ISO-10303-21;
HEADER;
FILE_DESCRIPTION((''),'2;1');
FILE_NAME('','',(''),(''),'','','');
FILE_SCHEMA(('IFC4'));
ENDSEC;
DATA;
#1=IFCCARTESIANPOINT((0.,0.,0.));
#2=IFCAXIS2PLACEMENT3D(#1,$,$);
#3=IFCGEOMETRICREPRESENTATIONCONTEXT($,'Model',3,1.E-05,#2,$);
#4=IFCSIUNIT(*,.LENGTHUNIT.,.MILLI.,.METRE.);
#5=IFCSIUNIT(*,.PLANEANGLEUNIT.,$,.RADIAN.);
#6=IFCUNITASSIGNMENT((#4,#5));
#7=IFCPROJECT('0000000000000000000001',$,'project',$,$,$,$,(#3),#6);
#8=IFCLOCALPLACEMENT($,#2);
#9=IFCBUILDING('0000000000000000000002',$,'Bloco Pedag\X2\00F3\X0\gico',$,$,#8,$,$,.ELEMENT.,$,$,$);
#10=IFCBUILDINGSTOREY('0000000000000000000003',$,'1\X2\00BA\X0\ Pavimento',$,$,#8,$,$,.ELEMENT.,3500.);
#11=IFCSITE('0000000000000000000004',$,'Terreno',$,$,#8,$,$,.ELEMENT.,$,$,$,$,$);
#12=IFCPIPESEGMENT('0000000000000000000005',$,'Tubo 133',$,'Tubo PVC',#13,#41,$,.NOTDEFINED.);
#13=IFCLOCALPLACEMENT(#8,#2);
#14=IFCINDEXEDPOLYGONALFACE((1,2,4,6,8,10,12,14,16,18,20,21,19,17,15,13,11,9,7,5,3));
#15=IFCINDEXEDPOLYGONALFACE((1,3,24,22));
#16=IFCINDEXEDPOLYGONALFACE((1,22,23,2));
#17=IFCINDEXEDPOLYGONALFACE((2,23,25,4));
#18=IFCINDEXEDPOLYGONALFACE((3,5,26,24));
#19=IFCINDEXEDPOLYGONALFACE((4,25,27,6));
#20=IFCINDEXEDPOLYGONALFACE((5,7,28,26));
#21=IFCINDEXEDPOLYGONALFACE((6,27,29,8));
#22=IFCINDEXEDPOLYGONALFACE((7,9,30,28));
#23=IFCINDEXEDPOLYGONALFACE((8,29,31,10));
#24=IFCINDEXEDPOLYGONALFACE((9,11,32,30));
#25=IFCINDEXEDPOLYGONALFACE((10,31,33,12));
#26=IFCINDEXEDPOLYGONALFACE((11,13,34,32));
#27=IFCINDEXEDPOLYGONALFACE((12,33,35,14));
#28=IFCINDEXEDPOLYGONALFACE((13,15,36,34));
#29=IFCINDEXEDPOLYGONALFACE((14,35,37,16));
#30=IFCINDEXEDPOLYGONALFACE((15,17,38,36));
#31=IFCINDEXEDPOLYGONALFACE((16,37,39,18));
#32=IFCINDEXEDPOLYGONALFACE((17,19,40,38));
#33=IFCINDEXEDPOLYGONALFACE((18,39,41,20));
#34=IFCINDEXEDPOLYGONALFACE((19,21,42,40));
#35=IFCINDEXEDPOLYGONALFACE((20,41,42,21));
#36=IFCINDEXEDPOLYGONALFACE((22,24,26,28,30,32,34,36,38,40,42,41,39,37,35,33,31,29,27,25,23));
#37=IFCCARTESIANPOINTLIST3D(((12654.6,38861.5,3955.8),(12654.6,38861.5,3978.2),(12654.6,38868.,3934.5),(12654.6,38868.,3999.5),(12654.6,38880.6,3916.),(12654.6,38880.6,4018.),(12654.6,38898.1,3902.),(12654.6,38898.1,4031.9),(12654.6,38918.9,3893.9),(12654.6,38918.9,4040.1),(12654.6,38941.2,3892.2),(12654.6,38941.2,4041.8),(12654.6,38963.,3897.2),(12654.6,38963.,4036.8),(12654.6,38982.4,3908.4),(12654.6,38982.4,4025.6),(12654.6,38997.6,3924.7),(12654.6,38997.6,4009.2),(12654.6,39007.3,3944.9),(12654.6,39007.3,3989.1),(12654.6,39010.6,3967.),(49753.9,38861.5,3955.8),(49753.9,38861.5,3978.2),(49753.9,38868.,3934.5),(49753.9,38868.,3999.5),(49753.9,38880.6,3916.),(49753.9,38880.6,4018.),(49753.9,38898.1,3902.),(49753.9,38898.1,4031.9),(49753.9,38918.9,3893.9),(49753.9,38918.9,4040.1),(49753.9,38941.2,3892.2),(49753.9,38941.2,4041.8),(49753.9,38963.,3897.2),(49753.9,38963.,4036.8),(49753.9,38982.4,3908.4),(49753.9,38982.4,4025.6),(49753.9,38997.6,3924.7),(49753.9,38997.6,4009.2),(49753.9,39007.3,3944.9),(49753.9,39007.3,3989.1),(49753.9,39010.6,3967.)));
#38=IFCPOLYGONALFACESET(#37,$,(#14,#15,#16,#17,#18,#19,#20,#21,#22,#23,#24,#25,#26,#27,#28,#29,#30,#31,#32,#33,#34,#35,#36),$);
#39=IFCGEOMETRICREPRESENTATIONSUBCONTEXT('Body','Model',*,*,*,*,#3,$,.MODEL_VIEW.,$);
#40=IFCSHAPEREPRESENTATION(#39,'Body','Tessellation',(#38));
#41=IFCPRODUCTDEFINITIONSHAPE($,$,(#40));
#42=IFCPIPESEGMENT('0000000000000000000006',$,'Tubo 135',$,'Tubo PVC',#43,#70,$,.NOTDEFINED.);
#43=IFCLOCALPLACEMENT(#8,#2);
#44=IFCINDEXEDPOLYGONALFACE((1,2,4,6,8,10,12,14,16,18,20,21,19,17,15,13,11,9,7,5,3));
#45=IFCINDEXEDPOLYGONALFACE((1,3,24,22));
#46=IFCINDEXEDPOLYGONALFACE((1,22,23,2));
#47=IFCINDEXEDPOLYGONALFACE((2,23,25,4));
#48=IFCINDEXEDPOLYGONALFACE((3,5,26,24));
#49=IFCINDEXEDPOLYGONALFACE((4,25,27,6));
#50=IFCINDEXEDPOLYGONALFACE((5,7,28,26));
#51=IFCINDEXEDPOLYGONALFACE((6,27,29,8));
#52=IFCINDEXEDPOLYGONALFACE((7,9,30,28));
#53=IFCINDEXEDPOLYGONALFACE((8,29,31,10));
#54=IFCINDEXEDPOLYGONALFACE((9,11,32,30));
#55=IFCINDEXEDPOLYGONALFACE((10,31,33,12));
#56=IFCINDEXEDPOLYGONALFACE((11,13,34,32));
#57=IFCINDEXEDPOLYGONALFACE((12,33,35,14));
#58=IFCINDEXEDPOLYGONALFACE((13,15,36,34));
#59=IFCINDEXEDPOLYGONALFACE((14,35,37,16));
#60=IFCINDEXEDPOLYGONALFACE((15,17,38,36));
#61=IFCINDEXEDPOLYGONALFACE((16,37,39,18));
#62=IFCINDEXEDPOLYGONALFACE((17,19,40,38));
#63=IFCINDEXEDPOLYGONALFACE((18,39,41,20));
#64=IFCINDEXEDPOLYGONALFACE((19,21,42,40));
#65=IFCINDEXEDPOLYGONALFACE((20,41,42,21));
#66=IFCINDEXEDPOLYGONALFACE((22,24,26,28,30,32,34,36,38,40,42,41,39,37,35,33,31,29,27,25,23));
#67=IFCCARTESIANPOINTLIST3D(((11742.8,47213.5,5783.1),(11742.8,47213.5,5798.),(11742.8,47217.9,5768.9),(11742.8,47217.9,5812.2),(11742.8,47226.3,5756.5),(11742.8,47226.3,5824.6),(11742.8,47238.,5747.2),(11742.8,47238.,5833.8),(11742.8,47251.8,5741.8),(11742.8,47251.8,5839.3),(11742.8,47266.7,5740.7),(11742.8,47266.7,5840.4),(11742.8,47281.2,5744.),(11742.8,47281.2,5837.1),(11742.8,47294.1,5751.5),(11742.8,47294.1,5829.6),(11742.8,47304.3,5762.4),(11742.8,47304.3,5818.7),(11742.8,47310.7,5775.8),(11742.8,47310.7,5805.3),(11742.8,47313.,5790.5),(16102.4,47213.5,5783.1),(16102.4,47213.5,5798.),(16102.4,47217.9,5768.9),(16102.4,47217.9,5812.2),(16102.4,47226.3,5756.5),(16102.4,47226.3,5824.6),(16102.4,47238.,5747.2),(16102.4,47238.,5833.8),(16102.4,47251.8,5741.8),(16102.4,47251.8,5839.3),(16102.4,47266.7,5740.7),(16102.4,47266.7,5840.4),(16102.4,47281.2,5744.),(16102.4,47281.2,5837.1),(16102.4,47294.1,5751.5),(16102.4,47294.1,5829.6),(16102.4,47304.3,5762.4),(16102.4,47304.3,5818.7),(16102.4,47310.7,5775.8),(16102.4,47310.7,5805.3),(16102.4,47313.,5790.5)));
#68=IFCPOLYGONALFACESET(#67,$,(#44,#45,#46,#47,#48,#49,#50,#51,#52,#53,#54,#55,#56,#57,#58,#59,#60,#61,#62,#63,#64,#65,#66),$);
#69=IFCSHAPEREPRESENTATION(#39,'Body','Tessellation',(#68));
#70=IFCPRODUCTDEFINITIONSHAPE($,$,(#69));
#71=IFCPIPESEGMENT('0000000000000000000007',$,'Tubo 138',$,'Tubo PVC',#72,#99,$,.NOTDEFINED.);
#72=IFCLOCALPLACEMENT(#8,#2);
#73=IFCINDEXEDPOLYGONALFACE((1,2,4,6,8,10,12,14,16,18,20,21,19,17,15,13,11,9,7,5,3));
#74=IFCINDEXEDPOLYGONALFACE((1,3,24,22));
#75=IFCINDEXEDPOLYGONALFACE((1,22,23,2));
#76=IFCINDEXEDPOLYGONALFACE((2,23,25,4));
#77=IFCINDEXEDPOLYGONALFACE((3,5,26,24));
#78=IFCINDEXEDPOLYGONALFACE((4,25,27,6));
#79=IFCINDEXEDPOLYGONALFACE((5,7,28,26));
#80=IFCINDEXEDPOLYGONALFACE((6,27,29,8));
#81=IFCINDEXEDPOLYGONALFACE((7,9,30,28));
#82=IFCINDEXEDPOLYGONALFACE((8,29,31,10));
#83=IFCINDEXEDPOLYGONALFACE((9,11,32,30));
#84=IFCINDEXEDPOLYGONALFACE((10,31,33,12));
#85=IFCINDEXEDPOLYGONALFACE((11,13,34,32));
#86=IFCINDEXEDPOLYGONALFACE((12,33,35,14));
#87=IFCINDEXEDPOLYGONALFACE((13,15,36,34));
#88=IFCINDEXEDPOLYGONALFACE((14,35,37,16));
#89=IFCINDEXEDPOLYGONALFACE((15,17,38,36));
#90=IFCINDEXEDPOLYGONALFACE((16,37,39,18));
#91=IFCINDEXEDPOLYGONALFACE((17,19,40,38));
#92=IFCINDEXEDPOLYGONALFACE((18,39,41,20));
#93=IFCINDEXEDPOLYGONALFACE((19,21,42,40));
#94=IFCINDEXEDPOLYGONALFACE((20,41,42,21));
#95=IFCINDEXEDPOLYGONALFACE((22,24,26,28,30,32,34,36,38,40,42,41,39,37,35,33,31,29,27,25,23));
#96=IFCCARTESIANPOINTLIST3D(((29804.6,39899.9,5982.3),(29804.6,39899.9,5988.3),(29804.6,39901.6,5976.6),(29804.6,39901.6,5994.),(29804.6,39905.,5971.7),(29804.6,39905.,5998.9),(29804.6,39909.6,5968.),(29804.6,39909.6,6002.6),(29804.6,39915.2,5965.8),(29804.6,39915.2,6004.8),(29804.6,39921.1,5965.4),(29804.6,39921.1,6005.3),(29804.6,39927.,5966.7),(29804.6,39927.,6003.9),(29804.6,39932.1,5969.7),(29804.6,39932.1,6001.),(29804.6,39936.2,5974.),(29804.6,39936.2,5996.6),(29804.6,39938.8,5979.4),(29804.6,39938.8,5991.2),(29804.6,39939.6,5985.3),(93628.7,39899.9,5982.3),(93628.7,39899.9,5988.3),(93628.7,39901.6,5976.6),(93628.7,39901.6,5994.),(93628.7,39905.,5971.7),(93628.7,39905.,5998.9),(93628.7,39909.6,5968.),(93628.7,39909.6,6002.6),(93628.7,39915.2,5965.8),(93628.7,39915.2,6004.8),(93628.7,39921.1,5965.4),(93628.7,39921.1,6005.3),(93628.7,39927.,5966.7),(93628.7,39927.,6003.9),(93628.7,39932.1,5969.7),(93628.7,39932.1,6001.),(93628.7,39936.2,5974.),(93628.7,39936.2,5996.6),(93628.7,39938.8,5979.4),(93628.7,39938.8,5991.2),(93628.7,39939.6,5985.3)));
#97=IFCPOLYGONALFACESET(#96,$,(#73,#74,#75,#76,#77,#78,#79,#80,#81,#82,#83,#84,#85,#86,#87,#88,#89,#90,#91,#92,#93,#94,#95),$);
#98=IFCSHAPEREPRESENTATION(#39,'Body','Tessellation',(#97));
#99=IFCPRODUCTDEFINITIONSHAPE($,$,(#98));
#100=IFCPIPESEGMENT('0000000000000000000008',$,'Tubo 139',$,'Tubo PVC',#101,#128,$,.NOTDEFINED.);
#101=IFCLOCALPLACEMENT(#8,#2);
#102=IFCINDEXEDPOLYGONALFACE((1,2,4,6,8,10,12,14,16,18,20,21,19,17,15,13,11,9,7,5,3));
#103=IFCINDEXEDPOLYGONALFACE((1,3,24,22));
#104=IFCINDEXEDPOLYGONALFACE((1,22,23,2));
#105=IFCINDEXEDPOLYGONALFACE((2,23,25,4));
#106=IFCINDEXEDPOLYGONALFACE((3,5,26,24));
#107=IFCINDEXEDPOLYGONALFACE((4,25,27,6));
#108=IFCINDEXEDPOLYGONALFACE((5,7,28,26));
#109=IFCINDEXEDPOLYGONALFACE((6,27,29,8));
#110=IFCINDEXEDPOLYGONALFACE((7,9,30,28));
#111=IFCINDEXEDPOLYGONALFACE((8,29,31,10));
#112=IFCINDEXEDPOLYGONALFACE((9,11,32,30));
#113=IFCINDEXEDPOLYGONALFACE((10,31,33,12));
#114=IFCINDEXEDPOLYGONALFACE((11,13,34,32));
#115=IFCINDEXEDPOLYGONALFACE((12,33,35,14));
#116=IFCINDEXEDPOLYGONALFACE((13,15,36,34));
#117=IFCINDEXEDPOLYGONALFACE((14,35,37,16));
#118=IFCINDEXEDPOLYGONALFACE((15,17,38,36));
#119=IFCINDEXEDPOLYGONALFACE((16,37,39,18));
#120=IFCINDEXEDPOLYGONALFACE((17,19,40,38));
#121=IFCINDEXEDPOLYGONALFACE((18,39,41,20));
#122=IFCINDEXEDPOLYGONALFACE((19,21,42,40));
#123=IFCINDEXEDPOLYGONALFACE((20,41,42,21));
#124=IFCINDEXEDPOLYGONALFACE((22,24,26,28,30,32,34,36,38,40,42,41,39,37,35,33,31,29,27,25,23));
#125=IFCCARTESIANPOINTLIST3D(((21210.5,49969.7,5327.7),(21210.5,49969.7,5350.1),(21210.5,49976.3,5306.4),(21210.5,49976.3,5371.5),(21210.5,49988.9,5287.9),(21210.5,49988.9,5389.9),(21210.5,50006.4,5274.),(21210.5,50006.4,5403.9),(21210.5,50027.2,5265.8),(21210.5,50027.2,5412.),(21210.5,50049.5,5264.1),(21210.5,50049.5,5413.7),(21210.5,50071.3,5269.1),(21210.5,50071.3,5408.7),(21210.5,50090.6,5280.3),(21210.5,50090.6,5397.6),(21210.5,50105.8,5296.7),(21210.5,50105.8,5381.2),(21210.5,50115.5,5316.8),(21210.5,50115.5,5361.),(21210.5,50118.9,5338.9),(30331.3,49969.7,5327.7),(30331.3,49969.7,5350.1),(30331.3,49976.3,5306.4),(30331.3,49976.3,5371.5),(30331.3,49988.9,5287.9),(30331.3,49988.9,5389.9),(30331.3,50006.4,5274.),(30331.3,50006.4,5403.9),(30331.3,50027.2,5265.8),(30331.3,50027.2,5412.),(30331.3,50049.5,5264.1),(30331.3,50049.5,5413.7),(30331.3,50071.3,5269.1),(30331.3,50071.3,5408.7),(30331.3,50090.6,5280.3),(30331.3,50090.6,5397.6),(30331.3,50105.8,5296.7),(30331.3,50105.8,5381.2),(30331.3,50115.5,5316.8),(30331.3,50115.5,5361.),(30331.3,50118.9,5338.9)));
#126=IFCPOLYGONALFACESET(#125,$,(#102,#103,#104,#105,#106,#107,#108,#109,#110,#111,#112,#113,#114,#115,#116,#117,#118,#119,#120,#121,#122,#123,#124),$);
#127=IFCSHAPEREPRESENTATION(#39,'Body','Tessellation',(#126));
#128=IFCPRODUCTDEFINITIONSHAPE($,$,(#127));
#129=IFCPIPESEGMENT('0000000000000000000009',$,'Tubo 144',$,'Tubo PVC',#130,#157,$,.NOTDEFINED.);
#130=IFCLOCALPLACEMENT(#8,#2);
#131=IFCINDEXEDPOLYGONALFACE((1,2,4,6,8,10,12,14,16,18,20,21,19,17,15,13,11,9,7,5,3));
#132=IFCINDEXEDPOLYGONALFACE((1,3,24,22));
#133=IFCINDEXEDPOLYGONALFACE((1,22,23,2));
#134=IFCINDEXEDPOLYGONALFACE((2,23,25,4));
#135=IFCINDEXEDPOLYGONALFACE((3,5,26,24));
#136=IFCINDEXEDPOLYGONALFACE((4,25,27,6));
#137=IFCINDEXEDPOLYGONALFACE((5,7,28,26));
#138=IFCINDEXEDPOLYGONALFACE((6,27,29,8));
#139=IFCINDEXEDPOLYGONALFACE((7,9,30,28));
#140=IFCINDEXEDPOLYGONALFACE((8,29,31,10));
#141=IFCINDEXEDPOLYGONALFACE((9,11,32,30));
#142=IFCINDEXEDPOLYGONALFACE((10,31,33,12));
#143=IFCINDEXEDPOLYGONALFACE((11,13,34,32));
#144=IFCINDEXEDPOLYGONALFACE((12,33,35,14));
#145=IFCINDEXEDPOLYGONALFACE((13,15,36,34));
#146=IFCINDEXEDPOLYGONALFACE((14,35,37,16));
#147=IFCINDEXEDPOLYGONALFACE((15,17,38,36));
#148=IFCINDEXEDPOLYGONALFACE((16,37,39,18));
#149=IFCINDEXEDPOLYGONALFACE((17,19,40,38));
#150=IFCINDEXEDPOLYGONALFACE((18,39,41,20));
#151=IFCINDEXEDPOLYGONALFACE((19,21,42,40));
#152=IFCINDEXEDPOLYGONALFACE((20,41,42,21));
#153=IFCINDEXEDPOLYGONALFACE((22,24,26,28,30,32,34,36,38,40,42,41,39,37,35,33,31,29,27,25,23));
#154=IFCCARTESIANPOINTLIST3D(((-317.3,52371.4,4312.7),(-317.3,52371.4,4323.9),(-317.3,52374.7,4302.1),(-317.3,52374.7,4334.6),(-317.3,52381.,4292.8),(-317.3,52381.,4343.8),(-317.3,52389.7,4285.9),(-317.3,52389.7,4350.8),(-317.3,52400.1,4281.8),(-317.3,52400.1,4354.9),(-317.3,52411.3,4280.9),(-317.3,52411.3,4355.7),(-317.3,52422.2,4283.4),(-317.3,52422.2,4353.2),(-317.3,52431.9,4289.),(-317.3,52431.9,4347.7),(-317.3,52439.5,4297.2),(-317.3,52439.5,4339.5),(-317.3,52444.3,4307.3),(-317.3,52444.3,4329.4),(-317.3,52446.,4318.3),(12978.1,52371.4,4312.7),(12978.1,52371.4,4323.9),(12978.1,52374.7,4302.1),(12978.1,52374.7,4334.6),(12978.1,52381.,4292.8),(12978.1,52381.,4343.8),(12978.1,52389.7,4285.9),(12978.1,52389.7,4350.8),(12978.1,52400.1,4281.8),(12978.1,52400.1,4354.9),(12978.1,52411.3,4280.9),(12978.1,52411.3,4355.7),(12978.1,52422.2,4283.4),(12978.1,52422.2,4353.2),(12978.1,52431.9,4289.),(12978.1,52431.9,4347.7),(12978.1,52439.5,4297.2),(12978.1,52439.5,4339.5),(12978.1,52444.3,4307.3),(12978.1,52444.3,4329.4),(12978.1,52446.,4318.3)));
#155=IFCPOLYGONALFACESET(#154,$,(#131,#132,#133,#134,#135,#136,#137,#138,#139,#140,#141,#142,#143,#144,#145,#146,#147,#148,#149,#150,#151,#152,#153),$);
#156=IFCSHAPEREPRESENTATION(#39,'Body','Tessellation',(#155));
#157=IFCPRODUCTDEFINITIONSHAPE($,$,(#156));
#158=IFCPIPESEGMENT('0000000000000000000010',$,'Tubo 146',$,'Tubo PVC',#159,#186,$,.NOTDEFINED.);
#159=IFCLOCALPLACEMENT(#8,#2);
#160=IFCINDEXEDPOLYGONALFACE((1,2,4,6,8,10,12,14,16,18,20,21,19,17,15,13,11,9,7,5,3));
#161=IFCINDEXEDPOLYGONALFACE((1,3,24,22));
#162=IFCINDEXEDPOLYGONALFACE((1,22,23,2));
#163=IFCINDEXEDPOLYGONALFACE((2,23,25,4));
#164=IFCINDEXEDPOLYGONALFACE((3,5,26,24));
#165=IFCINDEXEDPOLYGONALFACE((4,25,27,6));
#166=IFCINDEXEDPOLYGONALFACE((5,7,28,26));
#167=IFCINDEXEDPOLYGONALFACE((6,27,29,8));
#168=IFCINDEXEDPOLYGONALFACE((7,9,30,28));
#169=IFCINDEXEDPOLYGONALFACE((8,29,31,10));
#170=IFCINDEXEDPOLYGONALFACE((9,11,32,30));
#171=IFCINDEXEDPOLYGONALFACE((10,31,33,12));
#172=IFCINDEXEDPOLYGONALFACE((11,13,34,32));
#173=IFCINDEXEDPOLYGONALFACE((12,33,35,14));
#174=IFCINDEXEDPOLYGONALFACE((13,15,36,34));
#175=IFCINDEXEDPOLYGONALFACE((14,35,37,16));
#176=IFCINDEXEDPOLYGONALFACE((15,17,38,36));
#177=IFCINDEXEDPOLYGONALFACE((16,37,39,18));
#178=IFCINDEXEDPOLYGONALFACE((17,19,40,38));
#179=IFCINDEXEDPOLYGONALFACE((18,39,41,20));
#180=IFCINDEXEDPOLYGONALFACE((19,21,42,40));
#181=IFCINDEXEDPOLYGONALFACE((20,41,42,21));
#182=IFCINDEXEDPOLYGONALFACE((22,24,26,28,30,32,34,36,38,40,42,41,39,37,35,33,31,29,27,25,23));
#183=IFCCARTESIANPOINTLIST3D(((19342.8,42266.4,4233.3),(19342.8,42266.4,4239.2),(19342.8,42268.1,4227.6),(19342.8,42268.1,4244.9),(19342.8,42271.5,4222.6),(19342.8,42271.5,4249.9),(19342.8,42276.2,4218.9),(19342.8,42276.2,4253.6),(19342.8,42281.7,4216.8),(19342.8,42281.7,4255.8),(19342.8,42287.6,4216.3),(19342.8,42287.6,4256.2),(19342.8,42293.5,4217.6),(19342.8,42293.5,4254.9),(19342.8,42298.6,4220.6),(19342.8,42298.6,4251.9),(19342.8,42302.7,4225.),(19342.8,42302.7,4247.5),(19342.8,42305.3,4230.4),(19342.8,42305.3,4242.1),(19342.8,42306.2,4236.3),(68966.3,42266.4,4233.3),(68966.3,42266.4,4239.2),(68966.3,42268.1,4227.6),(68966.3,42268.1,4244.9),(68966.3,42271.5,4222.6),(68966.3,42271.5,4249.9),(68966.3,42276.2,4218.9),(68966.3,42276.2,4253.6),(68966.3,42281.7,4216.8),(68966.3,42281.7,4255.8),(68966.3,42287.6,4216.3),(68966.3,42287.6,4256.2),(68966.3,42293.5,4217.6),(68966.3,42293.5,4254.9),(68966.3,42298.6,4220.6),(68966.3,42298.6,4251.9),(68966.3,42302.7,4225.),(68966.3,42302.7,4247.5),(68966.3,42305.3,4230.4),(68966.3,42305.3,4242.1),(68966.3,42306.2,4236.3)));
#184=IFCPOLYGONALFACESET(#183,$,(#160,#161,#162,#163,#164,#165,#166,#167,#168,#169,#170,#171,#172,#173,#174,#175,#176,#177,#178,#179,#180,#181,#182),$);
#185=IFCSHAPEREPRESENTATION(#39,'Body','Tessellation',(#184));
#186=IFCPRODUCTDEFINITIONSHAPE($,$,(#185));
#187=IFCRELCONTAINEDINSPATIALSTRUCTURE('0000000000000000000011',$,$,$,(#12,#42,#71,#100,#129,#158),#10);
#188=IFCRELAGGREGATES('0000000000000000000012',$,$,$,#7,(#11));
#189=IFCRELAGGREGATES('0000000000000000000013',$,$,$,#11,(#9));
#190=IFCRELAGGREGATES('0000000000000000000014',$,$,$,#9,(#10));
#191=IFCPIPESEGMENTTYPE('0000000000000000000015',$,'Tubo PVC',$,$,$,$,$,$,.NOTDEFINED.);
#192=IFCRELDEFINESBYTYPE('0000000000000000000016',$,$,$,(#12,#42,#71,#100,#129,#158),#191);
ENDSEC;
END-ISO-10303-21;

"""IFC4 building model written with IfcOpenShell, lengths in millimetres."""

from ifc_helpers import new_model, si_unit, frame, origin, origin_2d, place, context, subcontext, project, spatial, circle, extrude, type_object, element, save


model = new_model("IFC4")

# Units and contexts
model_context = context("Model", 3, precision=1e-05, world=origin())
body_context = subcontext(model_context, "Body", "Model", "MODEL_VIEW")
ifc_project = project(units=[si_unit("LENGTHUNIT", "METRE", prefix="MILLI"), si_unit("PLANEANGLEUNIT", "RADIAN")], contexts=[model_context])

# Site, building, storey
placement = place(None, origin())
site = spatial("IfcSite", under=ifc_project, at=placement, Name="Terreno", CompositionType="ELEMENT")
building = spatial("IfcBuilding", under=site, at=placement, Name="Bloco Pedagógico", CompositionType="ELEMENT")
storey = spatial("IfcBuildingStorey", under=building, at=placement, Name="1º Pavimento", CompositionType="ELEMENT", Elevation=3500.0)

# Pipe segments
pipe_segment_type = type_object("IfcPipeSegmentType", Name="Tubo PVC", PredefinedType="NOTDEFINED")
pipe_segment_1_placement = place(None, frame((12654.6, 38935.6, 3967.0), z_axis=(1.0, 0.0, 0.0), x_axis=(0.0, 1.0, 0.0)))
element("IfcPipeSegment", 1, at=pipe_segment_1_placement, inside=storey, type_object=pipe_segment_type, Name="Tubo 133", ObjectType="Tubo PVC", PredefinedType="NOTDEFINED", context=body_context, shape_type="SweptSolid", body=[
    extrude(circle(Radius=75.0, at=origin_2d()), None, (0.0, 0.0, 1.0), 37099.3),
])
pipe_segment_2_placement = place(None, frame((11742.8, 47263.0, 5790.5), z_axis=(1.0, 0.0, 0.0), x_axis=(0.0, 1.0, 0.0)))
element("IfcPipeSegment", 2, at=pipe_segment_2_placement, inside=storey, type_object=pipe_segment_type, Name="Tubo 135", ObjectType="Tubo PVC", PredefinedType="NOTDEFINED", context=body_context, shape_type="SweptSolid", body=[
    extrude(circle(Radius=50.0, at=origin_2d()), None, (0.0, 0.0, 1.0), 4359.7),
])
pipe_segment_3_placement = place(None, frame((29804.6, 39919.6, 5985.3), z_axis=(1.0, 0.0, 0.0), x_axis=(0.0, 1.0, 0.0)))
element("IfcPipeSegment", 3, at=pipe_segment_3_placement, inside=storey, type_object=pipe_segment_type, Name="Tubo 138", ObjectType="Tubo PVC", PredefinedType="NOTDEFINED", context=body_context, shape_type="SweptSolid", body=[
    extrude(circle(Radius=20.0, at=origin_2d()), None, (0.0, 0.0, 1.0), 63824.0),
])
pipe_segment_4_placement = place(None, frame((21210.5, 50043.9, 5338.9), z_axis=(1.0, 0.0, 0.0), x_axis=(0.0, 1.0, 0.0)))
element("IfcPipeSegment", 4, at=pipe_segment_4_placement, inside=storey, type_object=pipe_segment_type, Name="Tubo 139", ObjectType="Tubo PVC", PredefinedType="NOTDEFINED", context=body_context, shape_type="SweptSolid", body=[
    extrude(circle(Radius=75.0, at=origin_2d()), None, (0.0, 0.0, 1.0), 9120.8),
])
pipe_segment_5_placement = place(None, frame((-317.3, 52408.5, 4318.3), z_axis=(1.0, 0.0, 0.0), x_axis=(0.0, 1.0, 0.0)))
element("IfcPipeSegment", 5, at=pipe_segment_5_placement, inside=storey, type_object=pipe_segment_type, Name="Tubo 144", ObjectType="Tubo PVC", PredefinedType="NOTDEFINED", context=body_context, shape_type="SweptSolid", body=[
    extrude(circle(Radius=37.5, at=origin_2d()), None, (0.0, 0.0, 1.0), 13295.3),
])
pipe_segment_6_placement = place(None, frame((19342.8, 42286.2, 4236.3), z_axis=(1.0, 0.0, 0.0), x_axis=(0.0, 1.0, 0.0)))
element("IfcPipeSegment", 6, at=pipe_segment_6_placement, inside=storey, type_object=pipe_segment_type, Name="Tubo 146", ObjectType="Tubo PVC", PredefinedType="NOTDEFINED", context=body_context, shape_type="SweptSolid", body=[
    extrude(circle(Radius=20.0, at=origin_2d()), None, (0.0, 0.0, 1.0), 49623.5),
])

save(model, "model.ifc")
